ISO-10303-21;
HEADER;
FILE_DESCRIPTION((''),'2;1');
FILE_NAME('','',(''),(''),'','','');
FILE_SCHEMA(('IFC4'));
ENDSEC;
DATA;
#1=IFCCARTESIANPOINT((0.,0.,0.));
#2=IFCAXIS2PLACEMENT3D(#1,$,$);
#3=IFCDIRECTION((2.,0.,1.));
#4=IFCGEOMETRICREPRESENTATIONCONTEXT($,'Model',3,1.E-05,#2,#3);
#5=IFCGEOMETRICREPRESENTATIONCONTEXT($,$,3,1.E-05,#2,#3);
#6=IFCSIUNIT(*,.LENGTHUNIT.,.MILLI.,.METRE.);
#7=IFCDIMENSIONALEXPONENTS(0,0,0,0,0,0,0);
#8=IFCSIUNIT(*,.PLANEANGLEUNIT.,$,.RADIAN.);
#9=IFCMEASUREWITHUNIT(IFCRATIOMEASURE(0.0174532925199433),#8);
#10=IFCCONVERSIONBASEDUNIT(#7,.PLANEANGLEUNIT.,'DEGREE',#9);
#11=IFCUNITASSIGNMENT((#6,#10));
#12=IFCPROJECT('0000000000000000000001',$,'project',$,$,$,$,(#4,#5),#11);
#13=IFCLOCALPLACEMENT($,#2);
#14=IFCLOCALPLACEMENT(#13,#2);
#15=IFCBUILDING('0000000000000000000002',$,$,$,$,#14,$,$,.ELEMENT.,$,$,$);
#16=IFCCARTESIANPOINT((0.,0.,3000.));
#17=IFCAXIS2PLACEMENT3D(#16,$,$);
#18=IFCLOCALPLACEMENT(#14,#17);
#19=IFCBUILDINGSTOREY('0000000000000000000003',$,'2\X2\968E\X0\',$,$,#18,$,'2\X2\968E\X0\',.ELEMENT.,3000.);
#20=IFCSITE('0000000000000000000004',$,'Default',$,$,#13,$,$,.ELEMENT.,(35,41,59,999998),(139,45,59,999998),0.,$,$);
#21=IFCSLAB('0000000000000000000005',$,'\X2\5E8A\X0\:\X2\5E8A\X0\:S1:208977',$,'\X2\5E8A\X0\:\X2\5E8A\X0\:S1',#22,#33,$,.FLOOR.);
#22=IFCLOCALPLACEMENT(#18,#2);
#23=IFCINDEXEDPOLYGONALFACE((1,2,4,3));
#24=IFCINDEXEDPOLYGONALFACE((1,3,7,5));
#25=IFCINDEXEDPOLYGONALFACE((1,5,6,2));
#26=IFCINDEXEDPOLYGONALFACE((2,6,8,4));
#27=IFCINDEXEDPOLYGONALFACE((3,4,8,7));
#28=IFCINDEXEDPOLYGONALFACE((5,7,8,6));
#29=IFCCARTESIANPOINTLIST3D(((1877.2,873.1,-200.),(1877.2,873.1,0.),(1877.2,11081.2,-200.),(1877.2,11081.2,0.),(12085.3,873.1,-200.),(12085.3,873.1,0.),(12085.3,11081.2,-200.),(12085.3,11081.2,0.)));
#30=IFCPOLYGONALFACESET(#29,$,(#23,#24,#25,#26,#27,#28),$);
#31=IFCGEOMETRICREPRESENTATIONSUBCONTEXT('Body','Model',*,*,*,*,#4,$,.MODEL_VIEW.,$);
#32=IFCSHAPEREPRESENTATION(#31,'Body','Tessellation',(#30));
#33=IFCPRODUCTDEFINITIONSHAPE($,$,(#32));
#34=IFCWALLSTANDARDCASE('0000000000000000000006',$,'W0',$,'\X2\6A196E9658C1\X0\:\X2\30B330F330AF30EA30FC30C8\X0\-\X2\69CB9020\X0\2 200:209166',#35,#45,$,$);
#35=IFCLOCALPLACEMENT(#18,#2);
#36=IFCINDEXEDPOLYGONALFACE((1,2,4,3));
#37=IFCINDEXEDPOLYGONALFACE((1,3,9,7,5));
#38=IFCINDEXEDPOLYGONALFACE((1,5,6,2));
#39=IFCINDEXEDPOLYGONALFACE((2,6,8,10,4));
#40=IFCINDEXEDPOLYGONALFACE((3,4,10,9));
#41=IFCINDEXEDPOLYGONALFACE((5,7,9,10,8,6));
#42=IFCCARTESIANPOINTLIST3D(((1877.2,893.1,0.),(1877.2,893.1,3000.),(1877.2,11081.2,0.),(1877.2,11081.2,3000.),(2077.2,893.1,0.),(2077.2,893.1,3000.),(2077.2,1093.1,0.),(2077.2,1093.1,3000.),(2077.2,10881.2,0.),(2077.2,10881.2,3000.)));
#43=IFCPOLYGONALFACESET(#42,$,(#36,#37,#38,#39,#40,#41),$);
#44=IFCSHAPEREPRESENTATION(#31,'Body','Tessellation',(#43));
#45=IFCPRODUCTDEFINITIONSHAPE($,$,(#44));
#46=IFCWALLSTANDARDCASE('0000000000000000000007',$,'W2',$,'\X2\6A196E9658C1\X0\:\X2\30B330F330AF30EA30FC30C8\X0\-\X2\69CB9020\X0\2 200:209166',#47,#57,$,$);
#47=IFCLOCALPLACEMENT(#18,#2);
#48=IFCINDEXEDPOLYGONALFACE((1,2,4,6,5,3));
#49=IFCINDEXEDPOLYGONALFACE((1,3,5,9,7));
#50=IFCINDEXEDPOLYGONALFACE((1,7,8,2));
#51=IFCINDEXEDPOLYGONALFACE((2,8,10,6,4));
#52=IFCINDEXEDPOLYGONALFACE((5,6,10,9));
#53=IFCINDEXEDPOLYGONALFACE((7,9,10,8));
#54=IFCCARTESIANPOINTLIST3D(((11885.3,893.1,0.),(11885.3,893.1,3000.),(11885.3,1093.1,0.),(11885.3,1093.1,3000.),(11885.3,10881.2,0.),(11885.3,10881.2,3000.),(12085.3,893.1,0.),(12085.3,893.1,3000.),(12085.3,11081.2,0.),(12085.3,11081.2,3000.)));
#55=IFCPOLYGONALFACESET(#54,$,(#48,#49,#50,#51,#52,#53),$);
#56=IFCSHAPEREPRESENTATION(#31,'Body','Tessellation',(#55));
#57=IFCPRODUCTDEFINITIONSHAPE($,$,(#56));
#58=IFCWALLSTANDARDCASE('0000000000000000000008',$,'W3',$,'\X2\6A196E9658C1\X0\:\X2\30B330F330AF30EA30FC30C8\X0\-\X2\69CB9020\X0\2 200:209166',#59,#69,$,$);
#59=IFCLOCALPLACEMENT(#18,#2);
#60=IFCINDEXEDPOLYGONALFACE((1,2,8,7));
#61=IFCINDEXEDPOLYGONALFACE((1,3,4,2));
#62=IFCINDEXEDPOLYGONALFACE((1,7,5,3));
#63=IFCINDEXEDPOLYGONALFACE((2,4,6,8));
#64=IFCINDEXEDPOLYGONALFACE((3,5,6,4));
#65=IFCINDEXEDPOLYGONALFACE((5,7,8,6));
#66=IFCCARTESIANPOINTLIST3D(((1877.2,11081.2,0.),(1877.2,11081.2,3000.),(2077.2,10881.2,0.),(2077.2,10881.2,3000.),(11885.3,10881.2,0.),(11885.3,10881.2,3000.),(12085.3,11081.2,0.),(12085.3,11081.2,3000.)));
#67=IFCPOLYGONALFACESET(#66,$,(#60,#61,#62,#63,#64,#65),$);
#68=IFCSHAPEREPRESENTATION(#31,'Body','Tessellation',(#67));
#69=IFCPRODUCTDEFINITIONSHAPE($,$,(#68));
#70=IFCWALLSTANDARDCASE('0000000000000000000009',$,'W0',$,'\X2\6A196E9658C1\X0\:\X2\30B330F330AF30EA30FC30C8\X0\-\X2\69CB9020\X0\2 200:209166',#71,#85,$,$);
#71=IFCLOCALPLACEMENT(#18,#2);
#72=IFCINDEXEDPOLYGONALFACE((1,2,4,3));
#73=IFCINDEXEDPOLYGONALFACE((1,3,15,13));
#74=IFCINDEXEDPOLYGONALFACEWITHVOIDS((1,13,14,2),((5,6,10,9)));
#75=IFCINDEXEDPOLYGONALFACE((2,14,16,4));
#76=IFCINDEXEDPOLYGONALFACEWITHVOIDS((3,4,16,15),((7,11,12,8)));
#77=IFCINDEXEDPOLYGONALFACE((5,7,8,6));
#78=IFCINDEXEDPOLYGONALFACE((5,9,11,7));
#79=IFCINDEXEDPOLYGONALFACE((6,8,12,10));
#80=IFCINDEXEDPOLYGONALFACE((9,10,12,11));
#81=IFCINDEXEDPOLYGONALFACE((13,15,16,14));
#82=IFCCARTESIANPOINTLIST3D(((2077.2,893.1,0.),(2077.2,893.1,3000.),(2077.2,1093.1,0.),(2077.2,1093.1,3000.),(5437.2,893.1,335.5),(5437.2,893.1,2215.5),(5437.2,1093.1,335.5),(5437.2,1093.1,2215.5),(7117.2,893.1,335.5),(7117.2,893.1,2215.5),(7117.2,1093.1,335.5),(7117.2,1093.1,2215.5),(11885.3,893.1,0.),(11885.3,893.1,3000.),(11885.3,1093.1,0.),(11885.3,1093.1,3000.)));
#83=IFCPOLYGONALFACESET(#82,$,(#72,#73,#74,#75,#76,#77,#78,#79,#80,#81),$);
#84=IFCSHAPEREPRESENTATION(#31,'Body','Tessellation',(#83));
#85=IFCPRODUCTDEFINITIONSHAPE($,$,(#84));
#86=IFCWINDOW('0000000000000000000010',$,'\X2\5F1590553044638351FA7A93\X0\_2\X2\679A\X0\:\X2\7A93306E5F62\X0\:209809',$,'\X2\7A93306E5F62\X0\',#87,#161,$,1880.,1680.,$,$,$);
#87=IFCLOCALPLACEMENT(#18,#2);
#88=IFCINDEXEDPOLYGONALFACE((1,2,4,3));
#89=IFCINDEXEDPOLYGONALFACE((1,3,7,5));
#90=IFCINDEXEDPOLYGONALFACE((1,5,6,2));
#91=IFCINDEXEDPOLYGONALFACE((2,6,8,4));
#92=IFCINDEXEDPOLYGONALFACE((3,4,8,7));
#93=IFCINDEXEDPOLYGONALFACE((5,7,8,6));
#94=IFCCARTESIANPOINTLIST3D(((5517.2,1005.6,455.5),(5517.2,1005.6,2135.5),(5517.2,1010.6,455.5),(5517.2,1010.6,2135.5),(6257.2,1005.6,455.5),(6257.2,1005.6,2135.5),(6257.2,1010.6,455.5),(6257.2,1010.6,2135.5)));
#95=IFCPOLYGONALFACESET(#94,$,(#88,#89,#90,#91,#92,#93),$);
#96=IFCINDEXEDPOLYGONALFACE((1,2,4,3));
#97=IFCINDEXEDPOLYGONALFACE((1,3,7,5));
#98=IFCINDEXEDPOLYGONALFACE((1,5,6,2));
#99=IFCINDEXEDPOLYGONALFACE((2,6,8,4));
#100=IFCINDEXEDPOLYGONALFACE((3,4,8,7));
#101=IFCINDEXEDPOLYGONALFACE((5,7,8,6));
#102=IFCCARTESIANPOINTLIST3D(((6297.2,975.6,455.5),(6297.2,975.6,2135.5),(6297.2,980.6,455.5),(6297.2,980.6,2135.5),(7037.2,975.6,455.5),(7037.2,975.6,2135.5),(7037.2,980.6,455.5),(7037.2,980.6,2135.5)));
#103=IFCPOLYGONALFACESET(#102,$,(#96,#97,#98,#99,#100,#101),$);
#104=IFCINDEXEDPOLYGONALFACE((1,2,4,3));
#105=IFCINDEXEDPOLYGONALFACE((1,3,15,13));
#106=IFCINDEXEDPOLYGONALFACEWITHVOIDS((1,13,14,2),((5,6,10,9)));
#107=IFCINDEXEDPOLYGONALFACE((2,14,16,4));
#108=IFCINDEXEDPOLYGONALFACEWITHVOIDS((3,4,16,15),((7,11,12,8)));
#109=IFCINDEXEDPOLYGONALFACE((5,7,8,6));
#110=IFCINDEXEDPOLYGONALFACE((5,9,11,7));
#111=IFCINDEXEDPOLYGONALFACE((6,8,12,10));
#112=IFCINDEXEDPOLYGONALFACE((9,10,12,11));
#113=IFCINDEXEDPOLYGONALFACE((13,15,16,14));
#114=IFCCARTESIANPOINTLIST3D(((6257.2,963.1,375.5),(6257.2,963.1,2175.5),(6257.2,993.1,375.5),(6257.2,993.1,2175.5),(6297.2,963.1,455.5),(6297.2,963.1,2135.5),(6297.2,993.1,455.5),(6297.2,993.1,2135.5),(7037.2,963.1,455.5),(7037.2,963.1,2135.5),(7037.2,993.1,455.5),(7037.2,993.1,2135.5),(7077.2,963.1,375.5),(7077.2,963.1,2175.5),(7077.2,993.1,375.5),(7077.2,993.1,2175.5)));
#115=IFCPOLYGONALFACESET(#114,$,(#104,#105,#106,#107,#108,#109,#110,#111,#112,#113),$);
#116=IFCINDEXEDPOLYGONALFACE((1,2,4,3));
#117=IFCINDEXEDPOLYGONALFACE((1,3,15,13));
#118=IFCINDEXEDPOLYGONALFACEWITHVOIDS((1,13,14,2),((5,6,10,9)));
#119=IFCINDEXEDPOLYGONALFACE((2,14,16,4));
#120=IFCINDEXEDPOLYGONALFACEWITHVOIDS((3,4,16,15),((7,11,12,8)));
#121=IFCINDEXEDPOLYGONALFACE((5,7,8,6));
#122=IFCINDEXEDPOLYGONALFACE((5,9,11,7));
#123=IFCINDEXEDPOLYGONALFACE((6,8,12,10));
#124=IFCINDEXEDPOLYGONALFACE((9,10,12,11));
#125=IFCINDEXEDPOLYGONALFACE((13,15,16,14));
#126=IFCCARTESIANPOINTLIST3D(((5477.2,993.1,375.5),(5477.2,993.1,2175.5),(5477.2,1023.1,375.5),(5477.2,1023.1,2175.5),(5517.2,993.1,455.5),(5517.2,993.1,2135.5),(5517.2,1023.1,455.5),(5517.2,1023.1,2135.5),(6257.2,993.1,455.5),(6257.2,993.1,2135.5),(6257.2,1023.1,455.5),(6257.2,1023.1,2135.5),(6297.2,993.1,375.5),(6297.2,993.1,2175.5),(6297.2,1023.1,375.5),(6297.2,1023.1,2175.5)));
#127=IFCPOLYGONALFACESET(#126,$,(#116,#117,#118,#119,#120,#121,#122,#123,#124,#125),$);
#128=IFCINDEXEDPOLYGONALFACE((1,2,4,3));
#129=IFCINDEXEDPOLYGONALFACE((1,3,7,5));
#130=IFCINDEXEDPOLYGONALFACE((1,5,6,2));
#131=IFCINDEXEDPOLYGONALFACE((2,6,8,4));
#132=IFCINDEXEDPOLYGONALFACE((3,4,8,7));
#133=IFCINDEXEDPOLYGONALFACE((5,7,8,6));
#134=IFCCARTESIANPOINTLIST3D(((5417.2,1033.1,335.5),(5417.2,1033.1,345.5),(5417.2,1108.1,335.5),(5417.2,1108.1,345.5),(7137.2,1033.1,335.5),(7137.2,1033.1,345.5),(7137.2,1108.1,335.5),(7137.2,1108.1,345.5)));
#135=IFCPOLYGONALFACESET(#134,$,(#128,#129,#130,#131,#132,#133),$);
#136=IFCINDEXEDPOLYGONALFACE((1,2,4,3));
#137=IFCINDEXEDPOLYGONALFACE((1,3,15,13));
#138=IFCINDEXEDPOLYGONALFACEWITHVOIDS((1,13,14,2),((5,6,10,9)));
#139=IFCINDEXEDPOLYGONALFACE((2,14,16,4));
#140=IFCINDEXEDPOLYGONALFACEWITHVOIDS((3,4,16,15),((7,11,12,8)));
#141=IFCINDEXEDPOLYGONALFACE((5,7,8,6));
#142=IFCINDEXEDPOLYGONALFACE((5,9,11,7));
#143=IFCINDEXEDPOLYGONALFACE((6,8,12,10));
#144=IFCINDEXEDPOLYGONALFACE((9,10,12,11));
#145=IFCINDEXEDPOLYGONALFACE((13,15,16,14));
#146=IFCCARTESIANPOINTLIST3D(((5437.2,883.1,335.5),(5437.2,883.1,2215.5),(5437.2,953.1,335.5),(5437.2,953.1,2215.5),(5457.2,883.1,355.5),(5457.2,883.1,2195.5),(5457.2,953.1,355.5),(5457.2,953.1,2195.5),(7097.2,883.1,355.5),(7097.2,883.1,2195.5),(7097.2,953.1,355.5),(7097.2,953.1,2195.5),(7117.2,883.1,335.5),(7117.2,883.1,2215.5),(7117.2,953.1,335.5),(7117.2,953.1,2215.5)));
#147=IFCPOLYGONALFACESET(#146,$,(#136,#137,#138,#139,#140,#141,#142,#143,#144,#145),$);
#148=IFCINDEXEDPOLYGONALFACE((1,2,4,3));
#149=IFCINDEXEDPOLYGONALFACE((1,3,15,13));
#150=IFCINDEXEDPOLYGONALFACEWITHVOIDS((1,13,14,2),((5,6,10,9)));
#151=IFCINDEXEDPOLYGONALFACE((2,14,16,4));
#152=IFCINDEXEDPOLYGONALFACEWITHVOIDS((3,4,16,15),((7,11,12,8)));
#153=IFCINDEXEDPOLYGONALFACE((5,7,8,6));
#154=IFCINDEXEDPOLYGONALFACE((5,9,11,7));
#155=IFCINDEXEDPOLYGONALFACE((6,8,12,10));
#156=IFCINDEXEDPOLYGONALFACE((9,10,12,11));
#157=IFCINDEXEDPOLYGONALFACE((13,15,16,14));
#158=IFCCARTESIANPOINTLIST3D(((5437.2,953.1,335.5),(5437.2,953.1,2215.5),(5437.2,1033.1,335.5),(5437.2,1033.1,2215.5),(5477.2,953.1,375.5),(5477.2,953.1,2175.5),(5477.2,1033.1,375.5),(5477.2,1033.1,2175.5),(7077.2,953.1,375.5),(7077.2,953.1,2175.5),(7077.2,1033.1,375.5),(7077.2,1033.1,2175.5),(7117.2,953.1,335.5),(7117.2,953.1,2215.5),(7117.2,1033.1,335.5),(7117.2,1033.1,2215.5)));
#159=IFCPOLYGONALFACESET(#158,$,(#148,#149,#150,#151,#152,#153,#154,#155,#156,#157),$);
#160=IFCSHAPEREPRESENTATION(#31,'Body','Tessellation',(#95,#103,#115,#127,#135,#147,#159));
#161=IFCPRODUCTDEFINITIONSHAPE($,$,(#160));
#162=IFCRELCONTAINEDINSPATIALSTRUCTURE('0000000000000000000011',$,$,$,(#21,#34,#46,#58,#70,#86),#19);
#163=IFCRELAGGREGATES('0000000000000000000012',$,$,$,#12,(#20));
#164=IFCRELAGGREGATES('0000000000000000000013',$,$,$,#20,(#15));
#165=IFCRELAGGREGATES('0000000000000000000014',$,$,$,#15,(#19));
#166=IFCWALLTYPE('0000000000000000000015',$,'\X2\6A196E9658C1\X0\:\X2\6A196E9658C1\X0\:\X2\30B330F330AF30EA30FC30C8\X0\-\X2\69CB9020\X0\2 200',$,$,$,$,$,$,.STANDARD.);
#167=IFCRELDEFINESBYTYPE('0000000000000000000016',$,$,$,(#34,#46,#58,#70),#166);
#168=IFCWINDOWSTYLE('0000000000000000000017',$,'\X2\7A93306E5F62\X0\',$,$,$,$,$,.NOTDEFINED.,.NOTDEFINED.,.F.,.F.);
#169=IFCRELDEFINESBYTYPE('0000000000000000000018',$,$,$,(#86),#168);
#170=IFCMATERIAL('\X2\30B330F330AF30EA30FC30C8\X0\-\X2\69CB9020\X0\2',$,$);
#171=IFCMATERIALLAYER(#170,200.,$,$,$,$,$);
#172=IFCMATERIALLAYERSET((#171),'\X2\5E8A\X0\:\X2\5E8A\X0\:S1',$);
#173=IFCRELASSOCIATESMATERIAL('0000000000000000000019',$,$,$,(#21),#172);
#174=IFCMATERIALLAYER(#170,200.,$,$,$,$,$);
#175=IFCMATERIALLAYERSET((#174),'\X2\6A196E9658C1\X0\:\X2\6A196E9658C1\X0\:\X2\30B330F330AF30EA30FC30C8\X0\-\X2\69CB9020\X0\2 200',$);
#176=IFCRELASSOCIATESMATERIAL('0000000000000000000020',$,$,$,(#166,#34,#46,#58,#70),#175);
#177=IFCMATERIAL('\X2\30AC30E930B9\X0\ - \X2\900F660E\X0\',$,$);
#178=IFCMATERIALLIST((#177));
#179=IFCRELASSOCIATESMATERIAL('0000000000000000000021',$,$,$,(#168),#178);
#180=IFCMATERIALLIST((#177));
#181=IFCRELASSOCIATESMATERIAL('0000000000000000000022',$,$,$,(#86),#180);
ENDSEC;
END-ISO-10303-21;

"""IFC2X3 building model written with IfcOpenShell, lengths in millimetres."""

from ifc_helpers import new_model, entity, si_unit, converted_unit, direction, frame, frame_2d, origin, origin_2d_with_axis, place, context, subcontext, project, spatial, polyline, rectangle, outline, extrude, source, transform, mapped, material, material_list, layer, layer_set, layer_usage, type_object, type_shapes, element, fill, save


model = new_model("IFC2X3")

# Units and contexts
model_context = context("Model", 3, precision=1e-05, world=origin(), true_north=direction((2.0, 0.0, 1.0)))
context_of_model = context(None, 3, precision=1e-05, world=origin(), true_north=direction((2.0, 0.0, 1.0)))
body_context = subcontext(model_context, "Body", "Model", "MODEL_VIEW")
ifc_project = project(units=[si_unit("LENGTHUNIT", "METRE", prefix="MILLI"), converted_unit("PLANEANGLEUNIT", "DEGREE", entity("IfcRatioMeasure", 0.0174532925199433), si_unit("PLANEANGLEUNIT", "RADIAN"), dimensions=[0, 0, 0, 0, 0, 0, 0])], contexts=[model_context, context_of_model])

# Site, building, storey
site_placement = place(None, origin())
site = spatial("IfcSite", under=ifc_project, at=site_placement, Name="Default", CompositionType="ELEMENT", RefLatitude=(35, 41, 59, 999998), RefLongitude=(139, 45, 59, 999998), RefElevation=0.0)
building_placement = place(site_placement, origin())
building = spatial("IfcBuilding", under=site, at=building_placement, CompositionType="ELEMENT")
storey_placement = place(building_placement, frame((0.0, 0.0, 3000.0)))
storey = spatial("IfcBuildingStorey", under=building, at=storey_placement, Name="2階", LongName="2階", CompositionType="ELEMENT", Elevation=3000.0)

# Slab
ifc_material_1 = material(Name="コンクリート-構造2")
ifc_layer_1 = layer(ifc_material_1, 200.0)
ifc_layer_set_1 = layer_set([ifc_layer_1], Name="床:床:S1")
ifc_layer_usage_1 = layer_usage(ifc_layer_set_1, "AXIS3", "POSITIVE", 0.0)
slab_1_placement = place(storey_placement, origin())
element("IfcSlab", 1, at=slab_1_placement, inside=storey, material=ifc_layer_usage_1, Name="床:床:S1:208977", ObjectType="床:床:S1", PredefinedType="FLOOR", context=body_context, shape_type="SweptSolid", body=[
    extrude(rectangle(XDim=10208.1, YDim=10208.1, at=origin_2d_with_axis()), frame((6981.3, 5977.2, 0.0), z_axis=(0.0, 0.0, -1.0), x_axis=(0.0, 1.0, 0.0)), (0.0, 0.0, 1.0), 200.0),
])

# Walls
ifc_layer_2 = layer(ifc_material_1, 200.0)
ifc_layer_set_2 = layer_set([ifc_layer_2], Name="標準壁:標準壁:コンクリート-構造2 200")
ifc_layer_usage_2 = layer_usage(ifc_layer_set_2, "AXIS2", "NEGATIVE", 100.0)
wall_type = type_object("IfcWallType", Name="標準壁:標準壁:コンクリート-構造2 200", PredefinedType="STANDARD", material=ifc_layer_set_2)
wall_1_placement = place(storey_placement, frame((1977.2, 11081.2, 0.0), z_axis=(0.0, 0.0, 1.0), x_axis=(0.0, -1.0, 0.0)))
element("IfcWallStandardCase", 2, at=wall_1_placement, inside=storey, type_object=wall_type, material=ifc_layer_usage_2, Name="W0", ObjectType="標準壁:コンクリート-構造2 200:209166", context=body_context, shape_type="SweptSolid", body=[
    extrude(outline(polyline([(10188.1, -100.0), (10188.1, 100.0), (9988.1, 100.0), (200.0, 100.0), (0.0, -100.0), (10188.1, -100.0)])), origin(), (0.0, 0.0, 1.0), 3000.0),
])
ifc_layer_usage_3 = layer_usage(ifc_layer_set_2, "AXIS2", "NEGATIVE", 100.0)
wall_2_placement = place(storey_placement, frame((11985.3, 893.1, 0.0), z_axis=(0.0, 0.0, 1.0), x_axis=(0.0, 1.0, 0.0)))
element("IfcWallStandardCase", 3, at=wall_2_placement, inside=storey, type_object=wall_type, material=ifc_layer_usage_3, Name="W2", ObjectType="標準壁:コンクリート-構造2 200:209166", context=body_context, shape_type="SweptSolid", body=[
    extrude(outline(polyline([(10188.1, -100.0), (9988.1, 100.0), (200.0, 100.0), (0.0, 100.0), (0.0, -100.0), (10188.1, -100.0)])), origin(), (0.0, 0.0, 1.0), 3000.0),
])
ifc_layer_usage_4 = layer_usage(ifc_layer_set_2, "AXIS2", "NEGATIVE", 100.0)
wall_3_placement = place(storey_placement, frame((12085.3, 10981.2, 0.0), z_axis=(0.0, 0.0, 1.0), x_axis=(-1.0, 0.0, 0.0)))
element("IfcWallStandardCase", 4, at=wall_3_placement, inside=storey, type_object=wall_type, material=ifc_layer_usage_4, Name="W3", ObjectType="標準壁:コンクリート-構造2 200:209166", context=body_context, shape_type="SweptSolid", body=[
    extrude(outline(polyline([(10208.1, -100.0), (10008.1, 100.0), (200.0, 100.0), (0.0, -100.0), (10208.1, -100.0)])), origin(), (0.0, 0.0, 1.0), 3000.0),
])

# Wall, opening, window
ifc_layer_usage_5 = layer_usage(ifc_layer_set_2, "AXIS2", "NEGATIVE", 100.0)
wall_4_placement = place(storey_placement, frame((2077.2, 993.1, 0.0)))
wall_4 = element("IfcWallStandardCase", 5, at=wall_4_placement, inside=storey, type_object=wall_type, material=ifc_layer_usage_5, Name="W0", ObjectType="標準壁:コンクリート-構造2 200:209166", context=body_context, shape_type="SweptSolid", body=[
    extrude(rectangle(XDim=9808.1, YDim=200.0, at=frame_2d((4904.0, 0.0), x_axis=(-1.0, 0.0))), origin(), (0.0, 0.0, 1.0), 3000.0),
])
opening_placement = place(wall_4_placement, frame((3360.0, -100.0, 335.5)))
opening = element("IfcOpeningElement", 6, at=opening_placement, cuts=wall_4, ObjectType="Opening", context=body_context, shape_type="SweptSolid", body=[
    extrude(rectangle(XDim=1880.0, YDim=1680.0, at=frame_2d((940.0, 840.0), x_axis=(-1.0, 0.0))), frame((0.0, 0.0, 0.0), z_axis=(0.0, 1.0, 0.0), x_axis=(0.0, 0.0, 1.0)), (0.0, 0.0, 1.0), 200.0),
])
ifc_material_2 = material(Name="ガラス - 透明")
ifc_material_list_1 = material_list([ifc_material_2])
ifc_material_list_2 = material_list([ifc_material_2])
window_style = type_object("IfcWindowStyle", Name="窓の形", ConstructionType="NOTDEFINED", OperationType="NOTDEFINED", ParameterTakesPrecedence=False, Sizeable=False, material=ifc_material_list_2)
shared_shape = source(origin(), body_context, "Body", "SweptSolid", [
    extrude(rectangle(XDim=5.0, YDim=740.0, at=frame_2d((0.0, 0.0), x_axis=(1.0, 0.0))), frame((450.0, 115.0, 120.0), z_axis=(0.0, 0.0, 1.0), x_axis=(0.0, 1.0, 0.0)), (0.0, 0.0, 1.0), 1680.0),
    extrude(rectangle(XDim=5.0, YDim=740.0, at=frame_2d((0.0, 0.0), x_axis=(1.0, 0.0))), frame((1230.0, 85.0, 120.0), z_axis=(0.0, 0.0, 1.0), x_axis=(0.0, 1.0, 0.0)), (0.0, 0.0, 1.0), 1680.0),
    extrude(outline(polyline([(-410.0, -900.0), (410.0, -900.0), (410.0, 900.0), (-410.0, 900.0), (-410.0, -900.0)]), holes=[polyline([(370.0, 820.0), (370.0, -860.0), (-370.0, -860.0), (-370.0, 820.0), (370.0, 820.0)])]), frame((1230.0, 70.0, 940.0), z_axis=(0.0, 1.0, 0.0), x_axis=(1.0, 0.0, 0.0)), (0.0, 0.0, 1.0), 30.0),
    extrude(outline(polyline([(-410.0, -900.0), (410.0, -900.0), (410.0, 900.0), (-410.0, 900.0), (-410.0, -900.0)]), holes=[polyline([(370.0, 820.0), (370.0, -860.0), (-370.0, -860.0), (-370.0, 820.0), (370.0, 820.0)])]), frame((450.0, 100.0, 940.0), z_axis=(0.0, 1.0, 0.0), x_axis=(1.0, 0.0, 0.0)), (0.0, 0.0, 1.0), 30.0),
    extrude(rectangle(XDim=1720.0, YDim=75.0, at=frame_2d((0.0, 0.0), x_axis=(1.0, 0.0))), frame((840.0, 177.5, 0.0), z_axis=(0.0, 0.0, 1.0), x_axis=(-1.0, 0.0, 0.0)), (0.0, 0.0, 1.0), 10.0),
    extrude(outline(polyline([(-940.0, -840.0), (940.0, -840.0), (940.0, 840.0), (-940.0, 840.0), (-940.0, -840.0)]), holes=[polyline([(920.0, 820.0), (920.0, -820.0), (-920.0, -820.0), (-920.0, 820.0), (920.0, 820.0)])]), frame((840.0, -10.0, 940.0), z_axis=(0.0, 1.0, 0.0), x_axis=(0.0, 0.0, -1.0)), (0.0, 0.0, 1.0), 70.0),
    extrude(outline(polyline([(-840.0, -940.0), (840.0, -940.0), (840.0, 940.0), (-840.0, 940.0), (-840.0, -940.0)]), holes=[polyline([(800.0, -900.0), (-800.0, -900.0), (-800.0, 900.0), (800.0, 900.0), (800.0, -900.0)])]), frame((840.0, 60.0, 940.0), z_axis=(0.0, 1.0, 0.0), x_axis=(1.0, 0.0, 0.0)), (0.0, 0.0, 1.0), 80.0),
])
type_shapes(window_style, [shared_shape])
window_placement = place(storey_placement, frame((5437.2, 893.1, 335.5)))
window = element("IfcWindow", 7, at=window_placement, inside=storey, type_object=window_style, material=ifc_material_list_1, Name="引違い掃出窓_2枚:窓の形:209809", ObjectType="窓の形", OverallHeight=1880.0, OverallWidth=1680.0, context=body_context, shape_type="MappedRepresentation", body=[
    mapped(shared_shape, transform((0.0, 0.0, 0.0), scale=1.0)),
])
fill(opening, window)

save(model, "model.ifc")
